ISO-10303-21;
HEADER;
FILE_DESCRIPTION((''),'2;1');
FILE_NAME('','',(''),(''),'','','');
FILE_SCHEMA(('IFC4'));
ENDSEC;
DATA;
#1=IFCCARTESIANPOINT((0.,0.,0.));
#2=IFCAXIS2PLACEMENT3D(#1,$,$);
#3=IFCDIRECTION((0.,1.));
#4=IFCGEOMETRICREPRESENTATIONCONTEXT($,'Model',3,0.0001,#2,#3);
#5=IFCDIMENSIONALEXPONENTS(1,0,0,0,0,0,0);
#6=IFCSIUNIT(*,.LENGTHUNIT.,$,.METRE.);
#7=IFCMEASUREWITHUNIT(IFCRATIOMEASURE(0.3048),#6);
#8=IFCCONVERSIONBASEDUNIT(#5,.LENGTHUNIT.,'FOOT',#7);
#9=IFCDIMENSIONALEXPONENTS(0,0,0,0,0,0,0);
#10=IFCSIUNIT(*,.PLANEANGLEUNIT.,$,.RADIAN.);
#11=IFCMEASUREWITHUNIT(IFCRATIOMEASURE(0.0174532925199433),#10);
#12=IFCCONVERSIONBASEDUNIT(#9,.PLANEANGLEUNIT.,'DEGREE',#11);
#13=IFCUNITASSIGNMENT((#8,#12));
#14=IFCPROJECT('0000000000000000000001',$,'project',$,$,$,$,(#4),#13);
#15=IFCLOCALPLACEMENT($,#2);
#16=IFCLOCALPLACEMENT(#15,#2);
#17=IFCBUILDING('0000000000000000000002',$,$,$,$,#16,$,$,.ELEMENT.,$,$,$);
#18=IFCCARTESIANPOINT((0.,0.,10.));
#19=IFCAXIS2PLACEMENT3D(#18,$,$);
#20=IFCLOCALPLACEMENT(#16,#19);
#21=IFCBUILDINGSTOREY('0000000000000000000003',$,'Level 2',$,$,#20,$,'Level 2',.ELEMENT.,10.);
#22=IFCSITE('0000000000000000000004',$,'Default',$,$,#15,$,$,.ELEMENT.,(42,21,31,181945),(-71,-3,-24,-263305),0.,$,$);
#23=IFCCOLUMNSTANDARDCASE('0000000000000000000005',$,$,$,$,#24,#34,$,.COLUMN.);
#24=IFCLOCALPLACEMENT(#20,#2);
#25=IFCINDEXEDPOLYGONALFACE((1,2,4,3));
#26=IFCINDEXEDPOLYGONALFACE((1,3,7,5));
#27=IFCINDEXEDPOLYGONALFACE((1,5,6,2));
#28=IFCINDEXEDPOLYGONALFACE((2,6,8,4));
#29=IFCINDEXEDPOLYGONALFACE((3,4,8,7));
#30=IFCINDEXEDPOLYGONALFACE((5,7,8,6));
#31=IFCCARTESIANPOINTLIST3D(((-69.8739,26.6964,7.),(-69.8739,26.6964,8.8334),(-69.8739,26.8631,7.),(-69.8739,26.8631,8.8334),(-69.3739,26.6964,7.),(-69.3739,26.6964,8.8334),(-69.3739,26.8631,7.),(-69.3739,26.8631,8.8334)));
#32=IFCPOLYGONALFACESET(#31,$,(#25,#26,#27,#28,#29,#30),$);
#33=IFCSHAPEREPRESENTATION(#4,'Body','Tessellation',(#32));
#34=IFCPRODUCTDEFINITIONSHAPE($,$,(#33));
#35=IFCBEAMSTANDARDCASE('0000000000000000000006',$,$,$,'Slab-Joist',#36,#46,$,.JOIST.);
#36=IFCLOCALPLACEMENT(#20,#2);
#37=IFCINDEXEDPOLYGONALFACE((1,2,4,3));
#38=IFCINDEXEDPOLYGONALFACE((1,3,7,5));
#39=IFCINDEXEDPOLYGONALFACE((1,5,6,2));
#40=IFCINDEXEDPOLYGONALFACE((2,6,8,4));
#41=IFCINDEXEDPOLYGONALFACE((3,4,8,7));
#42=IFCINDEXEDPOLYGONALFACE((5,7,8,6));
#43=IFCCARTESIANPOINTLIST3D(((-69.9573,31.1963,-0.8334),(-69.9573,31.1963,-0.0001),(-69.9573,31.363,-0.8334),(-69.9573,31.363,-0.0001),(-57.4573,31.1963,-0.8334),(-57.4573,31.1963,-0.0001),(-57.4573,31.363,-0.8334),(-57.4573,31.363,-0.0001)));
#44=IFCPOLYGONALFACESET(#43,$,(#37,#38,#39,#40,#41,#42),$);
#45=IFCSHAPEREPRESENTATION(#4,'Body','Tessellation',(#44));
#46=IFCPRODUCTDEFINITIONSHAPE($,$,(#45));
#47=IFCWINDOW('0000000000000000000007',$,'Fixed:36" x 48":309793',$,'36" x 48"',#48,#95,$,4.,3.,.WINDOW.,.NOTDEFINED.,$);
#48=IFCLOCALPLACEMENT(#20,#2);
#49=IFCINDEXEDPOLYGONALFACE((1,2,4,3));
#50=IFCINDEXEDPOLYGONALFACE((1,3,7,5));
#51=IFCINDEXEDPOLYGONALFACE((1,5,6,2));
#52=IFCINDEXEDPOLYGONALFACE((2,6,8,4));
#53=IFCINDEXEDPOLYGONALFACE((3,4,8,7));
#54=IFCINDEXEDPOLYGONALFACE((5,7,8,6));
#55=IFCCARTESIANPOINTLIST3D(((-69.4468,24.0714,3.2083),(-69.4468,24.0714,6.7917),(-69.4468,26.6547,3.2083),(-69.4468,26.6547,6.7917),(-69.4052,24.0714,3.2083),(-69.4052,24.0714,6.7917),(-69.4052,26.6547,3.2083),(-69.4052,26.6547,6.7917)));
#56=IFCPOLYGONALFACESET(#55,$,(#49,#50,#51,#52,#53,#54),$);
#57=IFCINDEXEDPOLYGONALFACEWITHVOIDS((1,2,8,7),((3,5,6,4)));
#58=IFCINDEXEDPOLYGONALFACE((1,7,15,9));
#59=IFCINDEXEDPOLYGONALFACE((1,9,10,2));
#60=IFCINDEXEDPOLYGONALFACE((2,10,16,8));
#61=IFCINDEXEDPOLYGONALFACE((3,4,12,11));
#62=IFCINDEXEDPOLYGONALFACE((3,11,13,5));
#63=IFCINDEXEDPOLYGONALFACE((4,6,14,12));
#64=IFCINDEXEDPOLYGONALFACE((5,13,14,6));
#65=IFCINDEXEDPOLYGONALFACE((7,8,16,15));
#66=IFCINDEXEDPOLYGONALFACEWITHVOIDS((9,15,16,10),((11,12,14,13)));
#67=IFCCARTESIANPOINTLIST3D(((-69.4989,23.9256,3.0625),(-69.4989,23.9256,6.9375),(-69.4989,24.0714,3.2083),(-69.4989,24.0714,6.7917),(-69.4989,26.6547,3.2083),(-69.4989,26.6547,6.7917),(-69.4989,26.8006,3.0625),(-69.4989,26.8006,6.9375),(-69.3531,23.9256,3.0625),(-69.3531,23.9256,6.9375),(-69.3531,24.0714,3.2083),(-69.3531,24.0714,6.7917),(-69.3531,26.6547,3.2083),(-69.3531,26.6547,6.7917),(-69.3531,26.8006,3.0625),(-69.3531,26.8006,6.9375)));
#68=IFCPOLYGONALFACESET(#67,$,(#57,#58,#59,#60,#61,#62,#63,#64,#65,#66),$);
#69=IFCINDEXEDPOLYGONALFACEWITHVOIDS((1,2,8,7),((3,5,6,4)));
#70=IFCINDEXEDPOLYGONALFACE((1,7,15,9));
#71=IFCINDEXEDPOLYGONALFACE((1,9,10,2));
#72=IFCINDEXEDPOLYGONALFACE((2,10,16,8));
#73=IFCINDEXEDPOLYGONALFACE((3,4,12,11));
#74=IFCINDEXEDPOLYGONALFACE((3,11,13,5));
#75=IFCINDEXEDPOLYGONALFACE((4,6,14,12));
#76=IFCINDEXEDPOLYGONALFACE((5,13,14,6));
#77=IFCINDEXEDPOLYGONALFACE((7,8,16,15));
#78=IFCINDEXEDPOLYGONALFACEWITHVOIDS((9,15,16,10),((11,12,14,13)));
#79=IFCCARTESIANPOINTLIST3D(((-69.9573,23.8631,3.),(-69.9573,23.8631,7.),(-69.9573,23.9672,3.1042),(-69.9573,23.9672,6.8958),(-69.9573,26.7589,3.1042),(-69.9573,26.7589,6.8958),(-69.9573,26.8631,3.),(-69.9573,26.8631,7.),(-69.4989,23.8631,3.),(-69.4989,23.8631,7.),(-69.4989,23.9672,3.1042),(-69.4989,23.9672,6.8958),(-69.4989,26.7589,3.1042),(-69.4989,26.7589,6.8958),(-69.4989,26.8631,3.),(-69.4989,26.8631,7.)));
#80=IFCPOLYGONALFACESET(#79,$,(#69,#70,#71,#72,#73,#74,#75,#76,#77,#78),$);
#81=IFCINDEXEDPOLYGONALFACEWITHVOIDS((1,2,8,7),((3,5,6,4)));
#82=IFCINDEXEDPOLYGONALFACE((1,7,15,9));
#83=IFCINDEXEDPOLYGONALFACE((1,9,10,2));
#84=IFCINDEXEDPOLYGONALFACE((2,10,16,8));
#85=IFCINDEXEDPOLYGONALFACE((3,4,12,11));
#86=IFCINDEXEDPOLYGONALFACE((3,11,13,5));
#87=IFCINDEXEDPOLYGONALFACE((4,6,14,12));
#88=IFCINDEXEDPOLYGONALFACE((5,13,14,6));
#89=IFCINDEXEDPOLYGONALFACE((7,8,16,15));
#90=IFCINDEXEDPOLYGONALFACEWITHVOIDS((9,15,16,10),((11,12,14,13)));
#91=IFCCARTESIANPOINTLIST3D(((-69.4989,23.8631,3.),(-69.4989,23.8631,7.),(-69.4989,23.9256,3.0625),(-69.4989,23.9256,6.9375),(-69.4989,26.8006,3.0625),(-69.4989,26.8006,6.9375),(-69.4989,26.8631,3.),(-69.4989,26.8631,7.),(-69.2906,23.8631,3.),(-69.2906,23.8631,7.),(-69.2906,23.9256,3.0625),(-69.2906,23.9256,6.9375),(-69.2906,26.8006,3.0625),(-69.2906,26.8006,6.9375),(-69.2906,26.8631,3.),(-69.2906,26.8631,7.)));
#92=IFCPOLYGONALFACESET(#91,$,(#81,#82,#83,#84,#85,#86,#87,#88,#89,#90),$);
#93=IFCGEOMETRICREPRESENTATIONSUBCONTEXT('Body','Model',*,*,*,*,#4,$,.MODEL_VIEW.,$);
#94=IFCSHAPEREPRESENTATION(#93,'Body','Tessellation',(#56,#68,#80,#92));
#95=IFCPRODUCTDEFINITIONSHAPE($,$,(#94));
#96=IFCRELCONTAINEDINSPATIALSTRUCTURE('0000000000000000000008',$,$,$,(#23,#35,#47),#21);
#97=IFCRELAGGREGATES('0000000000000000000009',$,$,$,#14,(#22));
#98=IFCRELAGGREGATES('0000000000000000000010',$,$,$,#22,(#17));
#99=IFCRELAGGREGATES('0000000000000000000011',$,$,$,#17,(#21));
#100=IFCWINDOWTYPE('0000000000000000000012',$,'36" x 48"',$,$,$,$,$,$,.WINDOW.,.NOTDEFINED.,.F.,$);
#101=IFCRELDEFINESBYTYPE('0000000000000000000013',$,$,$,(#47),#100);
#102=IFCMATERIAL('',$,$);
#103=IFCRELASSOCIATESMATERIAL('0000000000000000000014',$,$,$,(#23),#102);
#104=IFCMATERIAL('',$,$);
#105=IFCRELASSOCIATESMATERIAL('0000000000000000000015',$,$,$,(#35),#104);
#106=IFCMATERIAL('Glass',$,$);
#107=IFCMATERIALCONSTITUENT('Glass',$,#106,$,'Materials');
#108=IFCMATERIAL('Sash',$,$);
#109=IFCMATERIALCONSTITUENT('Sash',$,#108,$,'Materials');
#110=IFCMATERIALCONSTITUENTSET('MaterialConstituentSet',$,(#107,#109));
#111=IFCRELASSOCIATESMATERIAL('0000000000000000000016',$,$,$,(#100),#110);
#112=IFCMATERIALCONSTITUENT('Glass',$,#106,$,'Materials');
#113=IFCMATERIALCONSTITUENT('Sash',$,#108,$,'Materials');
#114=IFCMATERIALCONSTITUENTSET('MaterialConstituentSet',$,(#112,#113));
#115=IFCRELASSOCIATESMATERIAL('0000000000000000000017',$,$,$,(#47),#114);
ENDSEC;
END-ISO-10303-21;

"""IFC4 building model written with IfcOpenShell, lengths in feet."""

from ifc_helpers import new_model, entity, si_unit, converted_unit, direction, frame, frame_2d, origin, origin_with_axes, place, context, subcontext, project, spatial, polyline, rectangle, outline, extrude, source, transform, mapped, material, constituent, constituent_set, type_object, type_shapes, element, save


model = new_model("IFC4")

# Units and contexts
model_context = context("Model", 3, precision=0.0001, world=origin(), true_north=direction((0.0, 1.0)))
body_context = subcontext(model_context, "Body", "Model", "MODEL_VIEW")
ifc_project = project(units=[converted_unit("LENGTHUNIT", "FOOT", entity("IfcRatioMeasure", 0.3048), si_unit("LENGTHUNIT", "METRE"), dimensions=[1, 0, 0, 0, 0, 0, 0]), converted_unit("PLANEANGLEUNIT", "DEGREE", entity("IfcRatioMeasure", 0.0174532925199433), si_unit("PLANEANGLEUNIT", "RADIAN"), dimensions=[0, 0, 0, 0, 0, 0, 0])], contexts=[model_context])

# Site, building, storey
site_placement = place(None, origin())
site = spatial("IfcSite", under=ifc_project, at=site_placement, Name="Default", CompositionType="ELEMENT", RefLatitude=(42, 21, 31, 181945), RefLongitude=(-71, -3, -24, -263305), RefElevation=0.0)
building_placement = place(site_placement, origin())
building = spatial("IfcBuilding", under=site, at=building_placement, CompositionType="ELEMENT")
storey_placement = place(building_placement, frame((0.0, 0.0, 10.0)))
storey = spatial("IfcBuildingStorey", under=building, at=storey_placement, Name="Level 2", LongName="Level 2", CompositionType="ELEMENT", Elevation=10.0)

# Column
placement_1 = place(storey_placement, frame((-69.6239, 19.7797, 0.0), z_axis=(0.0, 0.0, 1.0), x_axis=(0.0, 1.0, 0.0)))
ifc_material_1 = material(Name="")
for number, where, z_axis, x_axis in (
    (1, (7.0, 0.0, 7.0), (0.0, 0.0, 1.0), (1.0, 0.0, 0.0)),
):
    element("IfcColumnStandardCase", number, at=place(placement_1, frame(where, z_axis=z_axis, x_axis=x_axis)), inside=storey, material=ifc_material_1, PredefinedType="COLUMN", context=model_context, shape_type="SweptSolid", body=[
        extrude(rectangle(XDim=0.1667, YDim=0.5), origin(), (0.0, 0.0, 1.0), 1.8334),
    ])

# Beam
ifc_material_2 = material(Name="")
placement_2 = place(storey_placement, frame((-69.9573, 31.2797, 0.0), z_axis=(0.0, 0.0, 1.0), x_axis=(1.0, 0.0, 0.0)))
beam_placement = place(placement_2, frame((0.0, 0.0, -0.4167), z_axis=(1.0, 0.0, 0.0), x_axis=(0.0, 1.0, 0.0)))
element("IfcBeamStandardCase", 2, at=beam_placement, inside=storey, material=ifc_material_2, ObjectType="Slab-Joist", PredefinedType="JOIST", context=model_context, shape_type="SweptSolid", body=[
    extrude(rectangle(XDim=0.1667, YDim=0.8333), origin_with_axes(), (0.0, 0.0, 1.0), 12.5),
])

# Window
ifc_material_3 = material(Name="Glass")
ifc_constituent_1 = constituent(ifc_material_3, Name="Glass", Category="Materials")
ifc_material_4 = material(Name="Sash")
ifc_constituent_2 = constituent(ifc_material_4, Name="Sash", Category="Materials")
ifc_constituent_set_1 = constituent_set(constituents=[ifc_constituent_1, ifc_constituent_2], Name="MaterialConstituentSet")
ifc_constituent_3 = constituent(ifc_material_3, Name="Glass", Category="Materials")
ifc_constituent_4 = constituent(ifc_material_4, Name="Sash", Category="Materials")
ifc_constituent_set_2 = constituent_set(constituents=[ifc_constituent_3, ifc_constituent_4], Name="MaterialConstituentSet")
window_type = type_object("IfcWindowType", Name="36\" x 48\"", ParameterTakesPrecedence=False, PartitioningType="NOTDEFINED", PredefinedType="WINDOW", material=ifc_constituent_set_2)
shared_shape = source(origin(), body_context, "Body", "SweptSolid", [
    extrude(rectangle(XDim=2.5833, YDim=0.0417, at=frame_2d((0.0, 0.0), x_axis=(1.0, 0.0))), frame((1.75, 0.5312, 0.2083)), (0.0, 0.0, 1.0), 3.5833),
    extrude(outline(polyline([(-1.4375, -1.9375), (1.4375, -1.9375), (1.4375, 1.9375), (-1.4375, 1.9375), (-1.4375, -1.9375)]), holes=[polyline([(-1.2917, -1.7917), (-1.2917, 1.7917), (1.2917, 1.7917), (1.2917, -1.7917), (-1.2917, -1.7917)])]), frame((1.75, 0.6042, 2.0), z_axis=(0.0, -1.0, 0.0), x_axis=(-1.0, 0.0, 0.0)), (0.0, 0.0, 1.0), 0.1458),
    extrude(outline(polyline([(-1.5, -2.0), (1.5, -2.0), (1.5, 2.0), (-1.5, 2.0), (-1.5, -2.0)]), holes=[polyline([(-1.3958, -1.8958), (-1.3958, 1.8958), (1.3958, 1.8958), (1.3958, -1.8958), (-1.3958, -1.8958)])]), frame((1.75, 0.4583, 2.0), z_axis=(0.0, -1.0, 0.0), x_axis=(-1.0, 0.0, 0.0)), (0.0, 0.0, 1.0), 0.4583),
    extrude(outline(polyline([(-2.0, -1.5), (2.0, -1.5), (2.0, 1.5), (-2.0, 1.5), (-2.0, -1.5)]), holes=[polyline([(-1.9375, -1.4375), (-1.9375, 1.4375), (1.9375, 1.4375), (1.9375, -1.4375), (-1.9375, -1.4375)])]), frame((1.75, 0.6667, 2.0), z_axis=(0.0, -1.0, 0.0), x_axis=(0.0, 0.0, -1.0)), (0.0, 0.0, 1.0), 0.2083),
])
type_shapes(window_type, [shared_shape])
placement_3 = place(placement_1, frame((7.0833, 0.3333, 3.0)))
window_placement = place(placement_3, frame((0.25, 0.0, 0.0), z_axis=(0.0, 0.0, 1.0), x_axis=(-1.0, 0.0, 0.0)))
element("IfcWindow", 3, at=window_placement, inside=storey, type_object=window_type, material=ifc_constituent_set_1, Name="Fixed:36\" x 48\":309793", ObjectType="36\" x 48\"", OverallHeight=4.0, OverallWidth=3.0, PartitioningType="NOTDEFINED", PredefinedType="WINDOW", context=body_context, shape_type="MappedRepresentation", body=[
    mapped(shared_shape, transform((0.0, 0.0, 0.0), scale=1.0)),
])

save(model, "model.ifc")
